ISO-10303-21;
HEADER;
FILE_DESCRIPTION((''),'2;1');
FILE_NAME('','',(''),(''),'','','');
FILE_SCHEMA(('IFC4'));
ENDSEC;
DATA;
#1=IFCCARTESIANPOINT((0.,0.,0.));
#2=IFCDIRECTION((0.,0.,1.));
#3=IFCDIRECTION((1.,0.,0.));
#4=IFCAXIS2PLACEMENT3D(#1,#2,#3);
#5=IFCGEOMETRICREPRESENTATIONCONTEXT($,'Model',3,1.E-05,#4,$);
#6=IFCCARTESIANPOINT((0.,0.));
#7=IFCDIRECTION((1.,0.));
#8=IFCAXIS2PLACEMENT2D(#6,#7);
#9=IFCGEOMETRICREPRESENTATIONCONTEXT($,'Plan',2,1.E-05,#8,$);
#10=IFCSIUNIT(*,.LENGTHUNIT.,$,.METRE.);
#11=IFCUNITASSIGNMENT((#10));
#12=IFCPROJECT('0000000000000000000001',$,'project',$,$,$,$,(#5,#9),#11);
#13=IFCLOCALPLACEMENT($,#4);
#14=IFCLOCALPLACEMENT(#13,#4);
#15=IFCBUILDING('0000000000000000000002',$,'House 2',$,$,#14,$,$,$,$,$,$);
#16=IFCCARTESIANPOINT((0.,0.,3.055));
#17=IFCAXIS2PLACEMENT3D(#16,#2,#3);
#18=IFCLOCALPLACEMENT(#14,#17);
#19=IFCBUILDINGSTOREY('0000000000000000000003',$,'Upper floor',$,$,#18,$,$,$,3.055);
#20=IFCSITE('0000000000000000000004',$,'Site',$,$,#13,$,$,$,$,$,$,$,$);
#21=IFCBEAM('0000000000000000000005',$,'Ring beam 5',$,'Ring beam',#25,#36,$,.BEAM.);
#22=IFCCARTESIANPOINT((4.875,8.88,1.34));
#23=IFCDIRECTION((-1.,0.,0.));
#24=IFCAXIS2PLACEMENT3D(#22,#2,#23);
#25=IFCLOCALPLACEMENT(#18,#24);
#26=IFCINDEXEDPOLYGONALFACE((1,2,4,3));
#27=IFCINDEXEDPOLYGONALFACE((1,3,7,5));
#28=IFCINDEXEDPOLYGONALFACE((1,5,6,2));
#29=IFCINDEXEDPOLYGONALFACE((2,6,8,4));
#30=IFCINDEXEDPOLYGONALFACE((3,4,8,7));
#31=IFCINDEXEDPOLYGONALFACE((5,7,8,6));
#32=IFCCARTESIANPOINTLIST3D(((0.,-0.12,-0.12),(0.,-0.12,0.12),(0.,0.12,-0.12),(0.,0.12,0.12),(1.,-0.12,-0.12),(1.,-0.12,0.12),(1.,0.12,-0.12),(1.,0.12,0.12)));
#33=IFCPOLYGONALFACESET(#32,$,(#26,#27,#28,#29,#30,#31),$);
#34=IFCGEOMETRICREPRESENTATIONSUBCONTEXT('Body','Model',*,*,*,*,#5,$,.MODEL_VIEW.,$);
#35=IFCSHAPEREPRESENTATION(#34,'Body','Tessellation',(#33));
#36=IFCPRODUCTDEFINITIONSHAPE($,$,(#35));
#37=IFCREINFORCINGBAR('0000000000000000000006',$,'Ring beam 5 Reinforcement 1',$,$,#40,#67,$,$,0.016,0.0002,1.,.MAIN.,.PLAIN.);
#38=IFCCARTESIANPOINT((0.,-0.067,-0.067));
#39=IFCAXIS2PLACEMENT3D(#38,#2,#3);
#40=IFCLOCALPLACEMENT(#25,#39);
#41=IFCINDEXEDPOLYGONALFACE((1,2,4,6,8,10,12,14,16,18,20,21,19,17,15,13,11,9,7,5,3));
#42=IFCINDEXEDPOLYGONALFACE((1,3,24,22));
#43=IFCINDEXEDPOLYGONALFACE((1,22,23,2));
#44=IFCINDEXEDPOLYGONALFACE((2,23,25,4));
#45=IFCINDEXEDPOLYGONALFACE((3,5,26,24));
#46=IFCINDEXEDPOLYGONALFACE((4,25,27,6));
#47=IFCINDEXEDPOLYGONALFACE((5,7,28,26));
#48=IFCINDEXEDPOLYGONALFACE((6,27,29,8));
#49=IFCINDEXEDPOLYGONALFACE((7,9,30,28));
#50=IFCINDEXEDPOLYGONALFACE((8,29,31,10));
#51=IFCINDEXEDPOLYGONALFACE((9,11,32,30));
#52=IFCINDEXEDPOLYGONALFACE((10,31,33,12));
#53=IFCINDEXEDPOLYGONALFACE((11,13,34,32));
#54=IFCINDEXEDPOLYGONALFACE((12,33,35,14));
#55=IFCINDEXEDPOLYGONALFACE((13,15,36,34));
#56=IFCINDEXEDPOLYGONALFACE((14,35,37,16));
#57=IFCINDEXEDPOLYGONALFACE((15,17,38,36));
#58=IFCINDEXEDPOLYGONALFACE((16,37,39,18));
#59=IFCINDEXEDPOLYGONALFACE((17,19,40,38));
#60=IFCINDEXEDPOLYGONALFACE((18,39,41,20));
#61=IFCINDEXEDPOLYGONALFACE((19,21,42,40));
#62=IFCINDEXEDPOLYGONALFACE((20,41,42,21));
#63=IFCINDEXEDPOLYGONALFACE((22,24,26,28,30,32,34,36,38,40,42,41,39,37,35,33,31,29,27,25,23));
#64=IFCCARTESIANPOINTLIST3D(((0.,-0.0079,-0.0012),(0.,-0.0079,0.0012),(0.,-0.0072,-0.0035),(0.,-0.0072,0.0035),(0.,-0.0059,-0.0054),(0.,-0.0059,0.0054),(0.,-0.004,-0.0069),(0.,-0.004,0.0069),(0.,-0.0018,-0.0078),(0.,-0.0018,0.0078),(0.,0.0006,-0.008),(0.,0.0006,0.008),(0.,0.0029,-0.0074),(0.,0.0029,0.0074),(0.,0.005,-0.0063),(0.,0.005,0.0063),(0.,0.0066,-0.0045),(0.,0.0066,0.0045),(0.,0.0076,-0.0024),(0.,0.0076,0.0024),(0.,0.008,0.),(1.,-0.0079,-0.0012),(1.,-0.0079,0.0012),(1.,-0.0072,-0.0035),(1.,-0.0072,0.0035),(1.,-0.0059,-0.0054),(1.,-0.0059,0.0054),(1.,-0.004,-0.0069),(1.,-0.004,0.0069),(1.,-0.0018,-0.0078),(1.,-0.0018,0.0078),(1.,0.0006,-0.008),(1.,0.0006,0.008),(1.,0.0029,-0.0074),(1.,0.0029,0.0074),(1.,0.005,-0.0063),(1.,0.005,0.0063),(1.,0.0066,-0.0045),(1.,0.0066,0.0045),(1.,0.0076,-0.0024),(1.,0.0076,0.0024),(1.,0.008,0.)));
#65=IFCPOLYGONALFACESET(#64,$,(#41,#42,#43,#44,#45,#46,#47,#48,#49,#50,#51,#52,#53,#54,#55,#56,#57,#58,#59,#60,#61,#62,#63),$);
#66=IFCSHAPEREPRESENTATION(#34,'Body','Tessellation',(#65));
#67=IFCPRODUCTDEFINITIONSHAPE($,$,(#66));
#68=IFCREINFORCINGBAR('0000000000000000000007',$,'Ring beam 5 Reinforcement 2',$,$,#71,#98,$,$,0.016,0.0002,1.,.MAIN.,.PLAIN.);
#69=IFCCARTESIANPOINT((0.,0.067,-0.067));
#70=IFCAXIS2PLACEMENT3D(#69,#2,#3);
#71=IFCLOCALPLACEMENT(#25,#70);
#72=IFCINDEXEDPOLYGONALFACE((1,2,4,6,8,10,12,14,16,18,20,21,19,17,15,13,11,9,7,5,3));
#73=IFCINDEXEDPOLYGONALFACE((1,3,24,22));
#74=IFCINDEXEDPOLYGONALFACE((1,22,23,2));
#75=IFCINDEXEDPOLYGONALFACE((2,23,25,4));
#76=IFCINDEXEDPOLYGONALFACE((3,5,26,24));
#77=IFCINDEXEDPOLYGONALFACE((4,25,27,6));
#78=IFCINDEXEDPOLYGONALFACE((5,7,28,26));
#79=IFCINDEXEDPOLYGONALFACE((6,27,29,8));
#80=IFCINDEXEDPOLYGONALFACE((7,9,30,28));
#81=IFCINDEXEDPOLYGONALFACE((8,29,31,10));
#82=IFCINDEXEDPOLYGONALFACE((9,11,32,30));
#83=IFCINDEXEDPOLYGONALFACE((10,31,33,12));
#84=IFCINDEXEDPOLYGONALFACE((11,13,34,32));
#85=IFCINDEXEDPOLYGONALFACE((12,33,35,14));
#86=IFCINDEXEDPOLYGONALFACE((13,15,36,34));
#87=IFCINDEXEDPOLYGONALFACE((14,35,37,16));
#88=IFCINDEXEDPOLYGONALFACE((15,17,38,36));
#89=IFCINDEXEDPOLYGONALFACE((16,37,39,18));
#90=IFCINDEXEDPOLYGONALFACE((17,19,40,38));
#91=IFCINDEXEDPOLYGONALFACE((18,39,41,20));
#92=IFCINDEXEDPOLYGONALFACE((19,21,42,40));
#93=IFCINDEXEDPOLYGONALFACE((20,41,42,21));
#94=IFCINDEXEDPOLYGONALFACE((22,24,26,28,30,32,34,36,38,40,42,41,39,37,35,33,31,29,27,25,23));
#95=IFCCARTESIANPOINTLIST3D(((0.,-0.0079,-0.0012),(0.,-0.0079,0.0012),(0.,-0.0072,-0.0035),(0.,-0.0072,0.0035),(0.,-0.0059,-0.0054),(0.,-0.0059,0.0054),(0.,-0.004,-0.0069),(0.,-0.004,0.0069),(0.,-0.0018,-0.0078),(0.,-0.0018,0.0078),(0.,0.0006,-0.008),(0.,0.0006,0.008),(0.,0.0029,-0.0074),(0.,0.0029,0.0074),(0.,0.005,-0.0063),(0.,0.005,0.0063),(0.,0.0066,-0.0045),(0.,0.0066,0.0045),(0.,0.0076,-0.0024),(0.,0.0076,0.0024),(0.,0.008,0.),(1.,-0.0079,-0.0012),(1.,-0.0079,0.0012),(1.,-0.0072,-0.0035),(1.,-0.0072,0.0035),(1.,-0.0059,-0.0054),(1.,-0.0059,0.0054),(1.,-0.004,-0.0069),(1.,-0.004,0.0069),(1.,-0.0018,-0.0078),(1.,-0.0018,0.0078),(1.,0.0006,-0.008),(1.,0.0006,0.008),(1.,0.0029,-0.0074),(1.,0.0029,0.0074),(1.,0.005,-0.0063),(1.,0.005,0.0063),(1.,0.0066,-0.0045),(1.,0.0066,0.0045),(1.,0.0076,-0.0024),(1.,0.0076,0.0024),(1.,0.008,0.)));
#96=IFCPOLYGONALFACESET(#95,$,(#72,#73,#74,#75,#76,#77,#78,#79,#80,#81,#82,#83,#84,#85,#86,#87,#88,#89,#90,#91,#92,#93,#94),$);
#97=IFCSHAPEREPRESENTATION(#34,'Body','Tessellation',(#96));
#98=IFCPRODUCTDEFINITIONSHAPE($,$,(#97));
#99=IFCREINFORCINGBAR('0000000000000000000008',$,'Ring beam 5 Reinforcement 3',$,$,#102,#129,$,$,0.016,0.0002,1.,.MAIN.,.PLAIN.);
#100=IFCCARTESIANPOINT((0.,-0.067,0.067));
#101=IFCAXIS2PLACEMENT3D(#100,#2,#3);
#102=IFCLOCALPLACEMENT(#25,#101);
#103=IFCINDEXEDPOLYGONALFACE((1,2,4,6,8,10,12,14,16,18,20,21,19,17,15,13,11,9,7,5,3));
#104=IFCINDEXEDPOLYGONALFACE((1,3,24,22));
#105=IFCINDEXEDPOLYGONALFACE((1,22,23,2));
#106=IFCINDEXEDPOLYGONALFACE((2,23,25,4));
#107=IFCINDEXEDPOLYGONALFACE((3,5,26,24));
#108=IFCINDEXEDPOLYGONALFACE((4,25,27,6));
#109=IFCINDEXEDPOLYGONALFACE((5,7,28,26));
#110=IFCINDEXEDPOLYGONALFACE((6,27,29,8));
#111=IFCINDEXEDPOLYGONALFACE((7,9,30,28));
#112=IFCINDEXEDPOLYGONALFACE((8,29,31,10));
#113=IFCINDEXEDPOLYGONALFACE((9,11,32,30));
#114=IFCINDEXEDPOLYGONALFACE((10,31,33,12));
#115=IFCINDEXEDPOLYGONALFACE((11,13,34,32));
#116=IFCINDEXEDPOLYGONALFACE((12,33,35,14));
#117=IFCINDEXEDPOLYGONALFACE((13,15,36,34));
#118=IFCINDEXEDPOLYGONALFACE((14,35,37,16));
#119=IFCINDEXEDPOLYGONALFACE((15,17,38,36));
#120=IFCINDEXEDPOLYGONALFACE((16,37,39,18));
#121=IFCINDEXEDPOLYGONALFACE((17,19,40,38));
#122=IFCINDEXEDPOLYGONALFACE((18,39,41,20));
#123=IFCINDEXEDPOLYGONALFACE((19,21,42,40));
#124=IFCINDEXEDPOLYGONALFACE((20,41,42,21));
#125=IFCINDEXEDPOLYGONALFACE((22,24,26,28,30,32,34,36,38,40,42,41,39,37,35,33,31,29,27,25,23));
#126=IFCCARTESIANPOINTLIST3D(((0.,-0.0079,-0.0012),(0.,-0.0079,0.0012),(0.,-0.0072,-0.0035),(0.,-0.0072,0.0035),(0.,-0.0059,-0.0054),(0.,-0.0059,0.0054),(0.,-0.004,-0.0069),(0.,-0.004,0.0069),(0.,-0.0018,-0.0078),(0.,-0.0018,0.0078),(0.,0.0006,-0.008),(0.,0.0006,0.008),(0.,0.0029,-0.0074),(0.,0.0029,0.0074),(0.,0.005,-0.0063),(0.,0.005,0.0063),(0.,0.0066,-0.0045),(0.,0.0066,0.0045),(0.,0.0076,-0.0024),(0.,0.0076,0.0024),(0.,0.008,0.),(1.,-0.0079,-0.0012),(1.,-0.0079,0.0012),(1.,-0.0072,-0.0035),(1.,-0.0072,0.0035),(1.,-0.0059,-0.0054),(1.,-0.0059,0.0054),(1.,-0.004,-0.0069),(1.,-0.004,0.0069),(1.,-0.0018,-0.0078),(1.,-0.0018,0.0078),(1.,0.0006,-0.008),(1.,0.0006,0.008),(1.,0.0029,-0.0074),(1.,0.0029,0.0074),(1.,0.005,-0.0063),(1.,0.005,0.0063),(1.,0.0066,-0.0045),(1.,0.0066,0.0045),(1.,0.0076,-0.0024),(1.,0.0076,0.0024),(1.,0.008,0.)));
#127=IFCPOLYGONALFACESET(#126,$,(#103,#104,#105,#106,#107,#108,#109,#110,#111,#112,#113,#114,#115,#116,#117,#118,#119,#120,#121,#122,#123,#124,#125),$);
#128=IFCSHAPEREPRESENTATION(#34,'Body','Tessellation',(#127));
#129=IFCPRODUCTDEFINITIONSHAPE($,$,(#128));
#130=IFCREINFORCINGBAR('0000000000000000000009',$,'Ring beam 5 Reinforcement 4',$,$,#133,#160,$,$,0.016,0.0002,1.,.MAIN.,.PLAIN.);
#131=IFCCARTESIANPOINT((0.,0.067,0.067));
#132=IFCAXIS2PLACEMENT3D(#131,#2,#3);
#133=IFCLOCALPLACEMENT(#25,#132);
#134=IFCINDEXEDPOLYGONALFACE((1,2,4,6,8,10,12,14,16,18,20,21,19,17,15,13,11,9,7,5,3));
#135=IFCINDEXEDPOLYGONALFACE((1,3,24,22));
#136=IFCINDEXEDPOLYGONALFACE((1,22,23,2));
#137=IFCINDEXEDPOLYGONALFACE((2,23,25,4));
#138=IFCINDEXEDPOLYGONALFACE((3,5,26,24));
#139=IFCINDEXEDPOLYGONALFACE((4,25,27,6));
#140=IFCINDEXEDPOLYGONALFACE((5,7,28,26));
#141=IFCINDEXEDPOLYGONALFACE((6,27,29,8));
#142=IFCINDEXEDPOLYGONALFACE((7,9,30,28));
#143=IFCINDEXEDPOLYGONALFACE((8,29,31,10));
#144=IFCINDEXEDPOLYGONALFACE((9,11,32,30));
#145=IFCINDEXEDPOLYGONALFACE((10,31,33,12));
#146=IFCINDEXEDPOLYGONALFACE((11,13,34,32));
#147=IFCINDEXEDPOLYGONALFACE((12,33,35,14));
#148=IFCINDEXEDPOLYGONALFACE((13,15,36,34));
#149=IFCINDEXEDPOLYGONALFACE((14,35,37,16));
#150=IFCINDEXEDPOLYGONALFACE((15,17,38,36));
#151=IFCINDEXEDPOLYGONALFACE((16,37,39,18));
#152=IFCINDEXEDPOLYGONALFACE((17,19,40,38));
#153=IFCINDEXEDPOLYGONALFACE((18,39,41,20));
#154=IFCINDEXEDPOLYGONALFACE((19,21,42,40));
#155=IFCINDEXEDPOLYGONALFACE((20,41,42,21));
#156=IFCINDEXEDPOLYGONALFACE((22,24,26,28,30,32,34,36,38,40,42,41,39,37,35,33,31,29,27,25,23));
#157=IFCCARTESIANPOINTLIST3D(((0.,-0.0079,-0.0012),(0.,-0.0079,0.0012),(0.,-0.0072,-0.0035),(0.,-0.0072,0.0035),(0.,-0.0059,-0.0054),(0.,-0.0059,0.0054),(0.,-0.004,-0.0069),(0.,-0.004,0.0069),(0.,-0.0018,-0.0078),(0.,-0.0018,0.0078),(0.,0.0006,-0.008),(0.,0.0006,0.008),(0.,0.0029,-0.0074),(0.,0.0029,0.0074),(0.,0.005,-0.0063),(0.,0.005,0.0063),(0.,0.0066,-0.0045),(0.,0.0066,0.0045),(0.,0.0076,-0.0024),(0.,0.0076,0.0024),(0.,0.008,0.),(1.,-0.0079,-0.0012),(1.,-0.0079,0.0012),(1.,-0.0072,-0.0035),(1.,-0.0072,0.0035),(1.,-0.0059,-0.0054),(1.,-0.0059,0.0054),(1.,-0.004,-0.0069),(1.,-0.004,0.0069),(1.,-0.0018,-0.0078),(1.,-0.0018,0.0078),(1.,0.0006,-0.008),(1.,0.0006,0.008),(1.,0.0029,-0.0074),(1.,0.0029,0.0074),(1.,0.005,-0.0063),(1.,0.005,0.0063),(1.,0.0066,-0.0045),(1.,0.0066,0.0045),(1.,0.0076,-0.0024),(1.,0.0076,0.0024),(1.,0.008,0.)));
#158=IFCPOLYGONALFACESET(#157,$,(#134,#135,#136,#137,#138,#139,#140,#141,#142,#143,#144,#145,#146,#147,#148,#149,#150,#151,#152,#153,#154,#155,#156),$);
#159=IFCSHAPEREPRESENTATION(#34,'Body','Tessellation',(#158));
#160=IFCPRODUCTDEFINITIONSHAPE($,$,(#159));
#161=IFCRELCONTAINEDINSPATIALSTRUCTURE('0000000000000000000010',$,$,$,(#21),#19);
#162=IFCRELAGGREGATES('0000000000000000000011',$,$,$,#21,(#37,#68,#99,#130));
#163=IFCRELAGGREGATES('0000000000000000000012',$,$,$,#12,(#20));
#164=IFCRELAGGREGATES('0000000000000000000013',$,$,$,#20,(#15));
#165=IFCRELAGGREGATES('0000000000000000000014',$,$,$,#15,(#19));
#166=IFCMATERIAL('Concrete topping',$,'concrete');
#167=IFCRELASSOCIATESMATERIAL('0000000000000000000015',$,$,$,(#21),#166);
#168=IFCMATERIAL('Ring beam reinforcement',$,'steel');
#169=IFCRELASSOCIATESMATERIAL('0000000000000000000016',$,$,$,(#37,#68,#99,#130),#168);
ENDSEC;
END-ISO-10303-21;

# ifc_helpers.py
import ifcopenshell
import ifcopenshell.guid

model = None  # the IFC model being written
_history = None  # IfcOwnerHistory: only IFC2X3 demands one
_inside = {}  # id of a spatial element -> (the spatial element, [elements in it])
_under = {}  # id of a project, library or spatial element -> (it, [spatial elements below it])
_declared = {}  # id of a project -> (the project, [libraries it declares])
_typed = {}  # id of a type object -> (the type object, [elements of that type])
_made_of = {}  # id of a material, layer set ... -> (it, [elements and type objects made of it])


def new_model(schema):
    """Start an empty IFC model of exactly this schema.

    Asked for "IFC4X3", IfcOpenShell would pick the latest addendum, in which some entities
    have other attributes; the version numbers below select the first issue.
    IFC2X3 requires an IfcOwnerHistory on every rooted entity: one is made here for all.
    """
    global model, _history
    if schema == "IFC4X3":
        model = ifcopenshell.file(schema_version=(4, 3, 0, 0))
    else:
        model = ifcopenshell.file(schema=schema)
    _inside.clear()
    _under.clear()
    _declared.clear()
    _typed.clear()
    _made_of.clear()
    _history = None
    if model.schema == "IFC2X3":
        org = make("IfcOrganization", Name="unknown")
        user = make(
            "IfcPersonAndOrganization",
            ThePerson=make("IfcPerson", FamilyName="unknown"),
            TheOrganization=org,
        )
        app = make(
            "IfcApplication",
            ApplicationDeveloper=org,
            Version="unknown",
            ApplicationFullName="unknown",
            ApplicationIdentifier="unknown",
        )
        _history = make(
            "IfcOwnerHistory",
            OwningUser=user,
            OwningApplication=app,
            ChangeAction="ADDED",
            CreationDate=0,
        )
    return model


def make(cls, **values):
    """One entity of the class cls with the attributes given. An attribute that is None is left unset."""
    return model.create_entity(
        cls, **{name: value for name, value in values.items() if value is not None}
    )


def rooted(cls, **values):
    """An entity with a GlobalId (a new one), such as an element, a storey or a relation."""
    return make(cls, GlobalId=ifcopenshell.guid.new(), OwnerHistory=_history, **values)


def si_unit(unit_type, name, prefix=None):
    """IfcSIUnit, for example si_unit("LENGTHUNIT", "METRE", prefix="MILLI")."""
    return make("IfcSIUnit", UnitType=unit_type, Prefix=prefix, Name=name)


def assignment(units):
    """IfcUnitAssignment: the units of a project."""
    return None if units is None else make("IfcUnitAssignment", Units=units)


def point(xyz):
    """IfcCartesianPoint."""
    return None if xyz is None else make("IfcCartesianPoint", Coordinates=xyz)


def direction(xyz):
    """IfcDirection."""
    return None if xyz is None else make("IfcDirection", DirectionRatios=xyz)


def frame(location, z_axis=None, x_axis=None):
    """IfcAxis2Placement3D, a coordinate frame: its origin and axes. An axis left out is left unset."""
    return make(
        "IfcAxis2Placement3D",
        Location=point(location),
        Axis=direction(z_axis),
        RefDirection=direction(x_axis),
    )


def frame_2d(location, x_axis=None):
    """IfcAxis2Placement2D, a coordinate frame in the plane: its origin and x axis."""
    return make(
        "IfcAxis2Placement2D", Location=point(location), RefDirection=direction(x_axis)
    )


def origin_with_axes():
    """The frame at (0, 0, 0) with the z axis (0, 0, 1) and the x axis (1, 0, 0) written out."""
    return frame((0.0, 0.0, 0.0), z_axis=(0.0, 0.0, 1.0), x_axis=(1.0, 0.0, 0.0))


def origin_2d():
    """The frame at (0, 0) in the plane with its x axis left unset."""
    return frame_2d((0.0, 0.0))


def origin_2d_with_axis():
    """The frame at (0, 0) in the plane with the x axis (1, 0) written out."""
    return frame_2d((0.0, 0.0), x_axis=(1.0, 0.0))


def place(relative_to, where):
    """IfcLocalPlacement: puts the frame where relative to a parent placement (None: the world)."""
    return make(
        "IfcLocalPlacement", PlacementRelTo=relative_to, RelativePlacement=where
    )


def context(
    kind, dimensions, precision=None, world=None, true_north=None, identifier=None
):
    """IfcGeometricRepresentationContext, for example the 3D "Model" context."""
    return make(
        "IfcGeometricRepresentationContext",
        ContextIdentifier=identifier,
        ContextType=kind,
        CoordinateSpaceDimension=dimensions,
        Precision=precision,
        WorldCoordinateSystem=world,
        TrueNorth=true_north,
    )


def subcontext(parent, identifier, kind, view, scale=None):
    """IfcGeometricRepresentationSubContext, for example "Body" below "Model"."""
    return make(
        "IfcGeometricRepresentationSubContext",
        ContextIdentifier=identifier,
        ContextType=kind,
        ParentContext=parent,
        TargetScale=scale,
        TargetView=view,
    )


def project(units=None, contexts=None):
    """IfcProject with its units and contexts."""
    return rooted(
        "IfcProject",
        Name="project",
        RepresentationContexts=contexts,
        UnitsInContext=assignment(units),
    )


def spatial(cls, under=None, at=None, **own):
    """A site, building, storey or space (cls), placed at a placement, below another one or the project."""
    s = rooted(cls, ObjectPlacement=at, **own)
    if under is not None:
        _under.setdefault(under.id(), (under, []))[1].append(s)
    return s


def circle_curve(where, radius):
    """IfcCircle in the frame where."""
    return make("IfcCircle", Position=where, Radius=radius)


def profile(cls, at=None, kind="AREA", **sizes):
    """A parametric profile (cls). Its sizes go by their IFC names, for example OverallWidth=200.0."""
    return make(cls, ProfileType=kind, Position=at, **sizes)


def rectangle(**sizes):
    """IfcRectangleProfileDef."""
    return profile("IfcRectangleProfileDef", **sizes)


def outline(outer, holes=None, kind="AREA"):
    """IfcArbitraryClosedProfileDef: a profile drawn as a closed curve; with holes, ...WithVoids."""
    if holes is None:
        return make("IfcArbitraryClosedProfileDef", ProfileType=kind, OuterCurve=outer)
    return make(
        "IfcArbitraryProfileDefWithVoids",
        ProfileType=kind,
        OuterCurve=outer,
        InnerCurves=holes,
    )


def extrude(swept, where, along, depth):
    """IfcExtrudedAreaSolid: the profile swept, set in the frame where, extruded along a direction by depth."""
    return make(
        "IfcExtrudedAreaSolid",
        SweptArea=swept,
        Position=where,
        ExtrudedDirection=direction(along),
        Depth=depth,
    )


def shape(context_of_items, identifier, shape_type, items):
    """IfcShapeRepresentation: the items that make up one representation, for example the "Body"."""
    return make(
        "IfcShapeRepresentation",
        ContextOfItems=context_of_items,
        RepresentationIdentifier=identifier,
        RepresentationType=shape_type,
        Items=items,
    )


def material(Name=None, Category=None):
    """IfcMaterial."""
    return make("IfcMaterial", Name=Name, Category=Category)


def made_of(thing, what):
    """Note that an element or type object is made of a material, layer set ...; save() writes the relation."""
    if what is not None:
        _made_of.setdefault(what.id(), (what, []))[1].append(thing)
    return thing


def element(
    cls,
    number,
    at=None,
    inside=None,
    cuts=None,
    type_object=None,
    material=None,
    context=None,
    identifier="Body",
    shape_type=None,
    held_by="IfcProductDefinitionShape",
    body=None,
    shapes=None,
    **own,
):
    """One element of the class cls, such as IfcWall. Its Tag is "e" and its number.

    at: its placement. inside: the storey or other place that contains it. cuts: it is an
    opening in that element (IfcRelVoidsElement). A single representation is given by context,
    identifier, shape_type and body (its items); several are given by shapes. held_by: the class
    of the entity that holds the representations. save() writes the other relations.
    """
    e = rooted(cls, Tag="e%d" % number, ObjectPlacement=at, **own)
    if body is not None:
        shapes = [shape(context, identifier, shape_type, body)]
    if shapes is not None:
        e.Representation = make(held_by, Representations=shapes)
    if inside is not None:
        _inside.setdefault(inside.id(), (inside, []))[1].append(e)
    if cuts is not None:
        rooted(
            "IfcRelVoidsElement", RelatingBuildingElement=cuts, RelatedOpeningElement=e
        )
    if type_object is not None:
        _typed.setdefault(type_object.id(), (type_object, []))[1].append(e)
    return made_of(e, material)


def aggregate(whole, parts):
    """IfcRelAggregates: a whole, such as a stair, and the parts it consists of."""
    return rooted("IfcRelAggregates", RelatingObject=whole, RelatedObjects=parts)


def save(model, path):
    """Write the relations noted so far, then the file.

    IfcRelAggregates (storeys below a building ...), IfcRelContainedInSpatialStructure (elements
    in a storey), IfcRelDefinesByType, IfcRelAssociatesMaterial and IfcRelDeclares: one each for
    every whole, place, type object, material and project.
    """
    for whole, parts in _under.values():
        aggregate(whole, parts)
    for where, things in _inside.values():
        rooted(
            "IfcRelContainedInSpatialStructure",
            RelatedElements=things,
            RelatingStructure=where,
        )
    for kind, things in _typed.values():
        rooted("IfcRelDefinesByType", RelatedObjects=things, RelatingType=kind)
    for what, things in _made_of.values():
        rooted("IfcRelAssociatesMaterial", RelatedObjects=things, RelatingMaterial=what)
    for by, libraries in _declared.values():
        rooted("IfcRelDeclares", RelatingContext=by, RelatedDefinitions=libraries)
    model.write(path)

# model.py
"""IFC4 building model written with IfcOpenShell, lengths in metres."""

from ifc_helpers import new_model, si_unit, frame, origin_with_axes, origin_2d, origin_2d_with_axis, place, context, subcontext, project, spatial, circle_curve, rectangle, outline, extrude, material, element, aggregate, save


model = new_model("IFC4")

# Units and contexts
model_context = context("Model", 3, precision=1e-05, world=origin_with_axes())
plan_context = context("Plan", 2, precision=1e-05, world=origin_2d_with_axis())
body_context_1 = subcontext(model_context, "Body", "Model", "MODEL_VIEW")
ifc_project = project(units=[si_unit("LENGTHUNIT", "METRE")], contexts=[model_context, plan_context])

# Site, building, storey
site_placement = place(None, origin_with_axes())
site = spatial("IfcSite", under=ifc_project, at=site_placement, Name="Site")
building_placement = place(site_placement, origin_with_axes())
building = spatial("IfcBuilding", under=site, at=building_placement, Name="House 2")
storey_placement = place(building_placement, frame((0.0, 0.0, 3.055), z_axis=(0.0, 0.0, 1.0), x_axis=(1.0, 0.0, 0.0)))
storey = spatial("IfcBuildingStorey", under=building, at=storey_placement, Name="Upper floor", Elevation=3.055)

# Beam
ifc_material_1 = material(Name="Concrete topping", Category="concrete")
beam_1_placement = place(storey_placement, frame((4.875, 8.88, 1.34), z_axis=(0.0, 0.0, 1.0), x_axis=(-1.0, 0.0, 0.0)))
beam_1 = element("IfcBeam", 1, at=beam_1_placement, inside=storey, material=ifc_material_1, Name="Ring beam 5", ObjectType="Ring beam", PredefinedType="BEAM", context=body_context_1, shape_type="SweptSolid", body=[
    extrude(rectangle(XDim=0.24, YDim=0.24), frame((0.0, 0.0, 0.0), z_axis=(1.0, 0.0, 0.0), x_axis=(0.0, 1.0, 0.0)), (0.0, 0.0, 1.0), 1.0),
])

# Reinforcing bars
ifc_material_2 = material(Name="Ring beam reinforcement", Category="steel")
reinforcing_bar_1_placement = place(beam_1_placement, frame((0.0, -0.067, -0.067), z_axis=(0.0, 0.0, 1.0), x_axis=(1.0, 0.0, 0.0)))
reinforcing_bar_1 = element("IfcReinforcingBar", 2, at=reinforcing_bar_1_placement, material=ifc_material_2, Name="Ring beam 5 Reinforcement 1", BarLength=1.0, BarSurface="PLAIN", CrossSectionArea=0.0002, NominalDiameter=0.016, PredefinedType="MAIN", context=body_context_1, shape_type="SweptSolid", body=[
    extrude(outline(circle_curve(origin_2d(), 0.008)), frame((0.0, 0.0, 0.0), z_axis=(1.0, 0.0, 0.0), x_axis=(0.0, 1.0, 0.0)), (0.0, 0.0, 1.0), 1.0),
])
reinforcing_bar_2_placement = place(beam_1_placement, frame((0.0, 0.067, -0.067), z_axis=(0.0, 0.0, 1.0), x_axis=(1.0, 0.0, 0.0)))
reinforcing_bar_2 = element("IfcReinforcingBar", 3, at=reinforcing_bar_2_placement, material=ifc_material_2, Name="Ring beam 5 Reinforcement 2", BarLength=1.0, BarSurface="PLAIN", CrossSectionArea=0.0002, NominalDiameter=0.016, PredefinedType="MAIN", context=body_context_1, shape_type="SweptSolid", body=[
    extrude(outline(circle_curve(origin_2d(), 0.008)), frame((0.0, 0.0, 0.0), z_axis=(1.0, 0.0, 0.0), x_axis=(0.0, 1.0, 0.0)), (0.0, 0.0, 1.0), 1.0),
])
reinforcing_bar_3_placement = place(beam_1_placement, frame((0.0, -0.067, 0.067), z_axis=(0.0, 0.0, 1.0), x_axis=(1.0, 0.0, 0.0)))
reinforcing_bar_3 = element("IfcReinforcingBar", 4, at=reinforcing_bar_3_placement, material=ifc_material_2, Name="Ring beam 5 Reinforcement 3", BarLength=1.0, BarSurface="PLAIN", CrossSectionArea=0.0002, NominalDiameter=0.016, PredefinedType="MAIN", context=body_context_1, shape_type="SweptSolid", body=[
    extrude(outline(circle_curve(origin_2d(), 0.008)), frame((0.0, 0.0, 0.0), z_axis=(1.0, 0.0, 0.0), x_axis=(0.0, 1.0, 0.0)), (0.0, 0.0, 1.0), 1.0),
])
reinforcing_bar_4_placement = place(beam_1_placement, frame((0.0, 0.067, 0.067), z_axis=(0.0, 0.0, 1.0), x_axis=(1.0, 0.0, 0.0)))
reinforcing_bar_4 = element("IfcReinforcingBar", 5, at=reinforcing_bar_4_placement, material=ifc_material_2, Name="Ring beam 5 Reinforcement 4", BarLength=1.0, BarSurface="PLAIN", CrossSectionArea=0.0002, NominalDiameter=0.016, PredefinedType="MAIN", context=body_context_1, shape_type="SweptSolid", body=[
    extrude(outline(circle_curve(origin_2d(), 0.008)), frame((0.0, 0.0, 0.0), z_axis=(1.0, 0.0, 0.0), x_axis=(0.0, 1.0, 0.0)), (0.0, 0.0, 1.0), 1.0),
])
aggregate(beam_1, [reinforcing_bar_1, reinforcing_bar_2, reinforcing_bar_3, reinforcing_bar_4])

save(model, "model.ifc")
